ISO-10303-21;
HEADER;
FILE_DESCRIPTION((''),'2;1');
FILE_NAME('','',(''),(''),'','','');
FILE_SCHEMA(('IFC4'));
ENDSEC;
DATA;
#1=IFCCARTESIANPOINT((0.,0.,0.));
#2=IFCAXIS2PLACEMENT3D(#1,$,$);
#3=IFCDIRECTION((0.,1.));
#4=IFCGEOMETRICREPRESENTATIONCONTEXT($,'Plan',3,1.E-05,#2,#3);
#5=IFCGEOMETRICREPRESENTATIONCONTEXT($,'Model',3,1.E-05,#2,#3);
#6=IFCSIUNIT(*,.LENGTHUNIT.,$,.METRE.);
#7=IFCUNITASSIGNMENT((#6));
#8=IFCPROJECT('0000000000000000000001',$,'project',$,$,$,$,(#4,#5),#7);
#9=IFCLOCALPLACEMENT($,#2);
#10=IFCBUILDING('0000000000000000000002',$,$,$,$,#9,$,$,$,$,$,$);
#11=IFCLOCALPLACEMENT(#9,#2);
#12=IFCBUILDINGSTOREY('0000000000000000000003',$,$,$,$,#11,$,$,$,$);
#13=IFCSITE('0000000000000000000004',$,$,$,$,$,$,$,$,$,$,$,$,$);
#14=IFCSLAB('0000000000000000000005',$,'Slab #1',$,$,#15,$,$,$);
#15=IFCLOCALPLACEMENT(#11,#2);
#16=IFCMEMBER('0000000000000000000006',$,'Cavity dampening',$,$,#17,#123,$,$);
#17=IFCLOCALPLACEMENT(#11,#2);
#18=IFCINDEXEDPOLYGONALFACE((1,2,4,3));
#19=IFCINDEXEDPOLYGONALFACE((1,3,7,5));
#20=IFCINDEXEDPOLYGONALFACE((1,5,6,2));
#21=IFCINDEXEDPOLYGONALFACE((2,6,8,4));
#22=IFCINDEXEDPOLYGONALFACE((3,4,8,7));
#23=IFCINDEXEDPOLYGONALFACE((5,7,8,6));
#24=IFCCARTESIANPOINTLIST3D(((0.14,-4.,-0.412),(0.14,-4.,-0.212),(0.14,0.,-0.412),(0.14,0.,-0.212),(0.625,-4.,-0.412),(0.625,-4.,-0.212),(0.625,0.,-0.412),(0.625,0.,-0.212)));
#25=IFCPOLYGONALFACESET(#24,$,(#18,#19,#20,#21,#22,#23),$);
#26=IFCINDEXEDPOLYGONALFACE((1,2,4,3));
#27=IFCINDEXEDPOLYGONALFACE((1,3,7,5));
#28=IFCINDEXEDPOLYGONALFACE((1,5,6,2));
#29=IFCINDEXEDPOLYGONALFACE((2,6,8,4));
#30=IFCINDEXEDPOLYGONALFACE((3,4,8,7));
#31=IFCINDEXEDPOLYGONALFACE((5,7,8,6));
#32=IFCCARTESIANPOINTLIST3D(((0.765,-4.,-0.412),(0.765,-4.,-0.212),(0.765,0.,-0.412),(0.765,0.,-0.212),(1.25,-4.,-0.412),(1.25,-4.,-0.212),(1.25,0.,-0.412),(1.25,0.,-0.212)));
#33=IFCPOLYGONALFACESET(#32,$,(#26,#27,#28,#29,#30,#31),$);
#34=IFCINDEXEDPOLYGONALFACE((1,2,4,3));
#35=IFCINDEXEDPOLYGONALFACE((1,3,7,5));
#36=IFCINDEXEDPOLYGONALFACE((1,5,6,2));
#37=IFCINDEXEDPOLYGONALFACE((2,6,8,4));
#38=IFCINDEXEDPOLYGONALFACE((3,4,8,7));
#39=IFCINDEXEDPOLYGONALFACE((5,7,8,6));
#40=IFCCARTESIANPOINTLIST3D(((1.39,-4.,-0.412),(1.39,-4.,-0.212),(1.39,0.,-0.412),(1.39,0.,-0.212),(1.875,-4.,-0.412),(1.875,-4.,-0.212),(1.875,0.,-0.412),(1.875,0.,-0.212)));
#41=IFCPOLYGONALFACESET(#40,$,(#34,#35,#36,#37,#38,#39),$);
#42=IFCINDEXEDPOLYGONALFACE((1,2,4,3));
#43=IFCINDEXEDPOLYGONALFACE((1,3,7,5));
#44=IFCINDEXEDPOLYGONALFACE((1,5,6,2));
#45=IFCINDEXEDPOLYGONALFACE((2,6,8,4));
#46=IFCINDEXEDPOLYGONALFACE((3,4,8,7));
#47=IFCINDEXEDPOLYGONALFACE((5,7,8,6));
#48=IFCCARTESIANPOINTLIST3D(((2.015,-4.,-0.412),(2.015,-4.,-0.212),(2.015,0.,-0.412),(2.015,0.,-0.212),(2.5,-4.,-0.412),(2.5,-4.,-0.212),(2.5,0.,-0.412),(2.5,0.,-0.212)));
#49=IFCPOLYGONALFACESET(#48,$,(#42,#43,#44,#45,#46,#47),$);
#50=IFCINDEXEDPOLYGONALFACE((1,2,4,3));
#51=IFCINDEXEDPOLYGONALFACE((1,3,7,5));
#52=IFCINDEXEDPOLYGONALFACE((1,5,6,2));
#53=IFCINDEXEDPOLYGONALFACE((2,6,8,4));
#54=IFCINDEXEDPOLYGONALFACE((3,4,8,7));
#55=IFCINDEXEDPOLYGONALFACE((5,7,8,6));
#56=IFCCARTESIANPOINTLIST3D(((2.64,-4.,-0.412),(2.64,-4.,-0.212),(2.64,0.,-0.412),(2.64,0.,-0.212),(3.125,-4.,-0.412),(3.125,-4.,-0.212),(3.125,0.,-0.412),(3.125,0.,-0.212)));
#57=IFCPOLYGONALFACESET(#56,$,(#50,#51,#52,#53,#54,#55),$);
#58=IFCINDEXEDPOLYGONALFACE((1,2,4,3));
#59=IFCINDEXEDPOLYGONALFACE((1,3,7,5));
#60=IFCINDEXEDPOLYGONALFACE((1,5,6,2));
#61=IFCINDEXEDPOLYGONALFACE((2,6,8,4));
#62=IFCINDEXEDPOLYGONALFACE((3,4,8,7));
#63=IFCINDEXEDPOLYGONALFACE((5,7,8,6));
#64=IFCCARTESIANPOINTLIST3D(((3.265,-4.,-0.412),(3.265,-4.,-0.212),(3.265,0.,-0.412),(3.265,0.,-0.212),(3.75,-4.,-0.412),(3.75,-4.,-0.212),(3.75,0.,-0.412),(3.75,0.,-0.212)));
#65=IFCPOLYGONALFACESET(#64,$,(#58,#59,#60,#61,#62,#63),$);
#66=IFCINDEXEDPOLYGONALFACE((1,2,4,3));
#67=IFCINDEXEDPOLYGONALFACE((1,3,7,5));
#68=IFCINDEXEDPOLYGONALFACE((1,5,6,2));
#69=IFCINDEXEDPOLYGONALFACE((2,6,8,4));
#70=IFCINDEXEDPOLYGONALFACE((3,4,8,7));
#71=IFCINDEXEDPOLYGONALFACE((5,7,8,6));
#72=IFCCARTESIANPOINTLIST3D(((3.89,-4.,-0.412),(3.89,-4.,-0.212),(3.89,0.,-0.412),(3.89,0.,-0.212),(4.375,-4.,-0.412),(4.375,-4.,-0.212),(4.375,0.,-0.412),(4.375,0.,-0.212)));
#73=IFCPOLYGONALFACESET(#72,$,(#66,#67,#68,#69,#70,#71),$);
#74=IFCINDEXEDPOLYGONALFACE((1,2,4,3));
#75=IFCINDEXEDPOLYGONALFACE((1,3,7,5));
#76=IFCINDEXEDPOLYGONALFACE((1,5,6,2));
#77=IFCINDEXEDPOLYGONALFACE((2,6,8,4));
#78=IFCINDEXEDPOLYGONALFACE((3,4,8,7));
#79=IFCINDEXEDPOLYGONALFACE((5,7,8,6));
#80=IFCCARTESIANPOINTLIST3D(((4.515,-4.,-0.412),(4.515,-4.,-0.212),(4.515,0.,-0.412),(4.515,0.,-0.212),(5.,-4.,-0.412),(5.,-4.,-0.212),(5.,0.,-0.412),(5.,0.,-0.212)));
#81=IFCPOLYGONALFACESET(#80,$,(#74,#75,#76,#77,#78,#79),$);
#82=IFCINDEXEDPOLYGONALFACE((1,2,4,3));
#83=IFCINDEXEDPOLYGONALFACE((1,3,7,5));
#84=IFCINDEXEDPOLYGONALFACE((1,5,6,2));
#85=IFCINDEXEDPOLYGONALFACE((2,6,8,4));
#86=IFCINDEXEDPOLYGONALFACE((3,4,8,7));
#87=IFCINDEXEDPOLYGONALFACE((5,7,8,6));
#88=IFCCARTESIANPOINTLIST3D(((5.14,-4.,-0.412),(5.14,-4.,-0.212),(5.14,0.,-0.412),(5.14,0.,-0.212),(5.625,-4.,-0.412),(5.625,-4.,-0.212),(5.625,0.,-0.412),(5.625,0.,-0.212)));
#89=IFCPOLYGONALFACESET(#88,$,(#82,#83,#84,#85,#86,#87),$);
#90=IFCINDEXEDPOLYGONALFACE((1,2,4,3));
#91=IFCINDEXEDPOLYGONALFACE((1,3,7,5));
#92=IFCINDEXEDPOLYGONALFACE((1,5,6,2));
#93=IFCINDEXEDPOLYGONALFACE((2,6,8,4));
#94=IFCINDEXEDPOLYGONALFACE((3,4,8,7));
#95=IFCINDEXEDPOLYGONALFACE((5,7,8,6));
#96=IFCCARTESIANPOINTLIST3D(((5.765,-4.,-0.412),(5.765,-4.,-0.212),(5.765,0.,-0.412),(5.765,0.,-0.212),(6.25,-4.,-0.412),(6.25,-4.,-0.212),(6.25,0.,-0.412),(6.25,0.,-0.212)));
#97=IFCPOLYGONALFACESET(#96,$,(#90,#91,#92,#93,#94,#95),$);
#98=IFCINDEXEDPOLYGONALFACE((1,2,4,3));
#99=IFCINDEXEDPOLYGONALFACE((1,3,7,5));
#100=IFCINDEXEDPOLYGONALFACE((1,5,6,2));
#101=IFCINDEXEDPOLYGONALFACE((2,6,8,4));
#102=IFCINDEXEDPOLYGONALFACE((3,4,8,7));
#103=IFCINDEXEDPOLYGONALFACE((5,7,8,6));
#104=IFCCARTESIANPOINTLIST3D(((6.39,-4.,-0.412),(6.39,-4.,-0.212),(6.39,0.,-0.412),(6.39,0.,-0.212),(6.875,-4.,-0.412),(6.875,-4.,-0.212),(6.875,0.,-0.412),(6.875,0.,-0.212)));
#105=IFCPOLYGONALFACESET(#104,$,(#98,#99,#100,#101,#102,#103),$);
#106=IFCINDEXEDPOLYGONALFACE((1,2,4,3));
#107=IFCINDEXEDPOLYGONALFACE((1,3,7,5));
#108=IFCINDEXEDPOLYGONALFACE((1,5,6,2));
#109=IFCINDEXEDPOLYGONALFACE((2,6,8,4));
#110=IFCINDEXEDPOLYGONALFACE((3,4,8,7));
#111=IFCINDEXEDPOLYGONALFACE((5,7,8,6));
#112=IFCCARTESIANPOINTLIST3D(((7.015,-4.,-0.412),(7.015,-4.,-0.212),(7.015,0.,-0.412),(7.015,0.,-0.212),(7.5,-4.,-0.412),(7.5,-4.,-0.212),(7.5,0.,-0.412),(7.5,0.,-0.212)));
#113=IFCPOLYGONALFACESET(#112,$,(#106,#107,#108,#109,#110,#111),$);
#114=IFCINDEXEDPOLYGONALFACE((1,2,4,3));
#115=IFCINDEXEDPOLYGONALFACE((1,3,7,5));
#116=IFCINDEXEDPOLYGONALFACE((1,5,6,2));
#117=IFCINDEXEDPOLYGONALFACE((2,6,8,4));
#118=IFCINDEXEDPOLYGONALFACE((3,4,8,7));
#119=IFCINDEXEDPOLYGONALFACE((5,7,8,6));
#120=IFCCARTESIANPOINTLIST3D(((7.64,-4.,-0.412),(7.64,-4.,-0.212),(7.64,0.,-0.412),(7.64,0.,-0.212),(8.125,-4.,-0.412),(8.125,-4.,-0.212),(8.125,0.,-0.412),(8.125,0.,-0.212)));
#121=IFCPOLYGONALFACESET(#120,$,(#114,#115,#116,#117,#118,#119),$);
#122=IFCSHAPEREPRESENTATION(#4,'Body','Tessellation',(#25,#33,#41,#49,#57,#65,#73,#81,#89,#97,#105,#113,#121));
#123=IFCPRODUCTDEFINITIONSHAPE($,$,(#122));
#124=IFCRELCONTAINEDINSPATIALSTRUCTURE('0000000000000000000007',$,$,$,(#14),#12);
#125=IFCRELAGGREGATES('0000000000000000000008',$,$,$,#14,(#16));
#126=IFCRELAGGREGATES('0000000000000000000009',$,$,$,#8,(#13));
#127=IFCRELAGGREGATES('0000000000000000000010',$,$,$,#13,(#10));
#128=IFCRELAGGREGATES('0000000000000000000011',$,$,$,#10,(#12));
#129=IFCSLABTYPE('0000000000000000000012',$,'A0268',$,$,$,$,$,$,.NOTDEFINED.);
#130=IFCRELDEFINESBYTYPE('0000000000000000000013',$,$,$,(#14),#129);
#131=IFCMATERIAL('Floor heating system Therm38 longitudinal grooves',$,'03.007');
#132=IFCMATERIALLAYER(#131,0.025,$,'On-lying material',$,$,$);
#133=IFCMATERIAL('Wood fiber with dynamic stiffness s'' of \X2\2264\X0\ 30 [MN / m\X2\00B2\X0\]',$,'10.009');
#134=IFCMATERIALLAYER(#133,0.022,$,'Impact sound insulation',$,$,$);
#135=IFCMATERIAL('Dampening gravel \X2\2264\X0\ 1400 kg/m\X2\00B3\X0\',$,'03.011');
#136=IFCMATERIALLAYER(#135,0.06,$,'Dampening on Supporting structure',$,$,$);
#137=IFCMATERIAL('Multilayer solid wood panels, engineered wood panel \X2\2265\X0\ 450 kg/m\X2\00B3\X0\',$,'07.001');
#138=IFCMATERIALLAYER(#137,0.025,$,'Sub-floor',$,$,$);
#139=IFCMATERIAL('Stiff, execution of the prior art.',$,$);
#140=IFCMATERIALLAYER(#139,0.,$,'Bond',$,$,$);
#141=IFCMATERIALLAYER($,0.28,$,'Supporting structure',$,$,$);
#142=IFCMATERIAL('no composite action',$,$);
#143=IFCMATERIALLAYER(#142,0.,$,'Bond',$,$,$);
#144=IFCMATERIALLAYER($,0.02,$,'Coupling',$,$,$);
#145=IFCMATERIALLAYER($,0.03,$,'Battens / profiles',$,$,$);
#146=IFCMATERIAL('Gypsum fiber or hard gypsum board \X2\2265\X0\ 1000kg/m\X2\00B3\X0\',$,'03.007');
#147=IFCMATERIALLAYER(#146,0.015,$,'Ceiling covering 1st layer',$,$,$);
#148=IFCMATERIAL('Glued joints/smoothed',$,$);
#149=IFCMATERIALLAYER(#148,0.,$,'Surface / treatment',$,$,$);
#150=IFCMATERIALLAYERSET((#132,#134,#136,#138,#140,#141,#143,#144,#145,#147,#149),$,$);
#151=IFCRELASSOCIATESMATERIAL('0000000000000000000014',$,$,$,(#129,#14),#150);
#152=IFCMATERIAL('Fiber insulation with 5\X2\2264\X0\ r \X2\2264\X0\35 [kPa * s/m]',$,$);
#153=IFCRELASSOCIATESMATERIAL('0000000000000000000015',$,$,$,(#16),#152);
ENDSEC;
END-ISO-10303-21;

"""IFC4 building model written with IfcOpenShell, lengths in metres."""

from ifc_helpers import new_model, si_unit, direction, frame, frame_2d, origin, place, context, project, spatial, rectangle, extrude, material, layer, layer_set, type_object, element, aggregate, save


model = new_model("IFC4")

# Units and contexts
plan_context = context("Plan", 3, precision=1e-05, world=origin(), true_north=direction((0.0, 1.0)))
model_context = context("Model", 3, precision=1e-05, world=origin(), true_north=direction((0.0, 1.0)))
ifc_project = project(units=[si_unit("LENGTHUNIT", "METRE")], contexts=[plan_context, model_context])

# Site, building, storey
site = spatial("IfcSite", under=ifc_project)
building_placement = place(None, origin())
building = spatial("IfcBuilding", under=site, at=building_placement)
storey_placement = place(building_placement, origin())
storey = spatial("IfcBuildingStorey", under=building, at=storey_placement)

# Slab, member
ifc_material_1 = material(Name="Floor heating system Therm38 longitudinal grooves", Category="03.007")
ifc_layer_1 = layer(ifc_material_1, 0.025, Name="On-lying material")
ifc_material_2 = material(Name="Wood fiber with dynamic stiffness s' of ≤ 30 [MN / m²]", Category="10.009")
ifc_layer_2 = layer(ifc_material_2, 0.022, Name="Impact sound insulation")
ifc_material_3 = material(Name="Dampening gravel ≤ 1400 kg/m³", Category="03.011")
ifc_layer_3 = layer(ifc_material_3, 0.06, Name="Dampening on Supporting structure")
ifc_material_4 = material(Name="Multilayer solid wood panels, engineered wood panel ≥ 450 kg/m³", Category="07.001")
ifc_layer_4 = layer(ifc_material_4, 0.025, Name="Sub-floor")
ifc_material_5 = material(Name="Stiff, execution of the prior art.")
ifc_layer_5 = layer(ifc_material_5, 0.0, Name="Bond")
ifc_layer_6 = layer(None, 0.28, Name="Supporting structure")
ifc_material_6 = material(Name="no composite action")
ifc_layer_7 = layer(ifc_material_6, 0.0, Name="Bond")
ifc_layer_8 = layer(None, 0.02, Name="Coupling")
ifc_layer_9 = layer(None, 0.03, Name="Battens / profiles")
ifc_material_7 = material(Name="Gypsum fiber or hard gypsum board ≥ 1000kg/m³", Category="03.007")
ifc_layer_10 = layer(ifc_material_7, 0.015, Name="Ceiling covering 1st layer")
ifc_material_8 = material(Name="Glued joints/smoothed")
ifc_layer_11 = layer(ifc_material_8, 0.0, Name="Surface / treatment")
ifc_layer_set = layer_set([ifc_layer_1, ifc_layer_2, ifc_layer_3, ifc_layer_4, ifc_layer_5, ifc_layer_6, ifc_layer_7, ifc_layer_8, ifc_layer_9, ifc_layer_10, ifc_layer_11])
slab_type = type_object("IfcSlabType", Name="A0268", PredefinedType="NOTDEFINED", material=ifc_layer_set)
slab_placement = place(None, frame((0.0, 0.0, 0.0), z_axis=(0.0, 0.0, -1.0), x_axis=(1.0, 0.0, 0.0)))
slab = element("IfcSlab", 1, at=slab_placement, inside=storey, type_object=slab_type, material=ifc_layer_set, Name="Slab #1")
ifc_material_9 = material(Name="Fiber insulation with 5≤ r ≤35 [kPa * s/m]")
member_1_placement = place(slab_placement, origin())
member_1 = element("IfcMember", 2, at=member_1_placement, material=ifc_material_9, Name="Cavity dampening", context=plan_context, shape_type="SweptSolid", body=[
    extrude(rectangle(XDim=0.485, YDim=0.2, at=frame_2d((0.2425, 0.1), x_axis=(1.0, 0.0))), frame((0.14, 4.0, 0.212), z_axis=(0.0, -1.0, 0.0), x_axis=(1.0, 0.0, 0.0)), (0.0, 0.0, 1.0), 4.0),
    extrude(rectangle(XDim=0.485, YDim=0.2, at=frame_2d((0.2425, 0.1), x_axis=(1.0, 0.0))), frame((0.765, 4.0, 0.212), z_axis=(0.0, -1.0, 0.0), x_axis=(1.0, 0.0, 0.0)), (0.0, 0.0, 1.0), 4.0),
    extrude(rectangle(XDim=0.485, YDim=0.2, at=frame_2d((0.2425, 0.1), x_axis=(1.0, 0.0))), frame((1.39, 4.0, 0.212), z_axis=(0.0, -1.0, 0.0), x_axis=(1.0, 0.0, 0.0)), (0.0, 0.0, 1.0), 4.0),
    extrude(rectangle(XDim=0.485, YDim=0.2, at=frame_2d((0.2425, 0.1), x_axis=(1.0, 0.0))), frame((2.015, 4.0, 0.212), z_axis=(0.0, -1.0, 0.0), x_axis=(1.0, 0.0, 0.0)), (0.0, 0.0, 1.0), 4.0),
    extrude(rectangle(XDim=0.485, YDim=0.2, at=frame_2d((0.2425, 0.1), x_axis=(1.0, 0.0))), frame((2.64, 4.0, 0.212), z_axis=(0.0, -1.0, 0.0), x_axis=(1.0, 0.0, 0.0)), (0.0, 0.0, 1.0), 4.0),
    extrude(rectangle(XDim=0.485, YDim=0.2, at=frame_2d((0.2425, 0.1), x_axis=(1.0, 0.0))), frame((3.265, 4.0, 0.212), z_axis=(0.0, -1.0, 0.0), x_axis=(1.0, 0.0, 0.0)), (0.0, 0.0, 1.0), 4.0),
    extrude(rectangle(XDim=0.485, YDim=0.2, at=frame_2d((0.2425, 0.1), x_axis=(1.0, 0.0))), frame((3.89, 4.0, 0.212), z_axis=(0.0, -1.0, 0.0), x_axis=(1.0, 0.0, 0.0)), (0.0, 0.0, 1.0), 4.0),
    extrude(rectangle(XDim=0.485, YDim=0.2, at=frame_2d((0.2425, 0.1), x_axis=(1.0, 0.0))), frame((4.515, 4.0, 0.212), z_axis=(0.0, -1.0, 0.0), x_axis=(1.0, 0.0, 0.0)), (0.0, 0.0, 1.0), 4.0),
    extrude(rectangle(XDim=0.485, YDim=0.2, at=frame_2d((0.2425, 0.1), x_axis=(1.0, 0.0))), frame((5.14, 4.0, 0.212), z_axis=(0.0, -1.0, 0.0), x_axis=(1.0, 0.0, 0.0)), (0.0, 0.0, 1.0), 4.0),
    extrude(rectangle(XDim=0.485, YDim=0.2, at=frame_2d((0.2425, 0.1), x_axis=(1.0, 0.0))), frame((5.765, 4.0, 0.212), z_axis=(0.0, -1.0, 0.0), x_axis=(1.0, 0.0, 0.0)), (0.0, 0.0, 1.0), 4.0),
    extrude(rectangle(XDim=0.485, YDim=0.2, at=frame_2d((0.2425, 0.1), x_axis=(1.0, 0.0))), frame((6.39, 4.0, 0.212), z_axis=(0.0, -1.0, 0.0), x_axis=(1.0, 0.0, 0.0)), (0.0, 0.0, 1.0), 4.0),
    extrude(rectangle(XDim=0.485, YDim=0.2, at=frame_2d((0.2425, 0.1), x_axis=(1.0, 0.0))), frame((7.015, 4.0, 0.212), z_axis=(0.0, -1.0, 0.0), x_axis=(1.0, 0.0, 0.0)), (0.0, 0.0, 1.0), 4.0),
    extrude(rectangle(XDim=0.485, YDim=0.2, at=frame_2d((0.2425, 0.1), x_axis=(1.0, 0.0))), frame((7.64, 4.0, 0.212), z_axis=(0.0, -1.0, 0.0), x_axis=(1.0, 0.0, 0.0)), (0.0, 0.0, 1.0), 4.0),
])
aggregate(slab, [member_1])

save(model, "model.ifc")
